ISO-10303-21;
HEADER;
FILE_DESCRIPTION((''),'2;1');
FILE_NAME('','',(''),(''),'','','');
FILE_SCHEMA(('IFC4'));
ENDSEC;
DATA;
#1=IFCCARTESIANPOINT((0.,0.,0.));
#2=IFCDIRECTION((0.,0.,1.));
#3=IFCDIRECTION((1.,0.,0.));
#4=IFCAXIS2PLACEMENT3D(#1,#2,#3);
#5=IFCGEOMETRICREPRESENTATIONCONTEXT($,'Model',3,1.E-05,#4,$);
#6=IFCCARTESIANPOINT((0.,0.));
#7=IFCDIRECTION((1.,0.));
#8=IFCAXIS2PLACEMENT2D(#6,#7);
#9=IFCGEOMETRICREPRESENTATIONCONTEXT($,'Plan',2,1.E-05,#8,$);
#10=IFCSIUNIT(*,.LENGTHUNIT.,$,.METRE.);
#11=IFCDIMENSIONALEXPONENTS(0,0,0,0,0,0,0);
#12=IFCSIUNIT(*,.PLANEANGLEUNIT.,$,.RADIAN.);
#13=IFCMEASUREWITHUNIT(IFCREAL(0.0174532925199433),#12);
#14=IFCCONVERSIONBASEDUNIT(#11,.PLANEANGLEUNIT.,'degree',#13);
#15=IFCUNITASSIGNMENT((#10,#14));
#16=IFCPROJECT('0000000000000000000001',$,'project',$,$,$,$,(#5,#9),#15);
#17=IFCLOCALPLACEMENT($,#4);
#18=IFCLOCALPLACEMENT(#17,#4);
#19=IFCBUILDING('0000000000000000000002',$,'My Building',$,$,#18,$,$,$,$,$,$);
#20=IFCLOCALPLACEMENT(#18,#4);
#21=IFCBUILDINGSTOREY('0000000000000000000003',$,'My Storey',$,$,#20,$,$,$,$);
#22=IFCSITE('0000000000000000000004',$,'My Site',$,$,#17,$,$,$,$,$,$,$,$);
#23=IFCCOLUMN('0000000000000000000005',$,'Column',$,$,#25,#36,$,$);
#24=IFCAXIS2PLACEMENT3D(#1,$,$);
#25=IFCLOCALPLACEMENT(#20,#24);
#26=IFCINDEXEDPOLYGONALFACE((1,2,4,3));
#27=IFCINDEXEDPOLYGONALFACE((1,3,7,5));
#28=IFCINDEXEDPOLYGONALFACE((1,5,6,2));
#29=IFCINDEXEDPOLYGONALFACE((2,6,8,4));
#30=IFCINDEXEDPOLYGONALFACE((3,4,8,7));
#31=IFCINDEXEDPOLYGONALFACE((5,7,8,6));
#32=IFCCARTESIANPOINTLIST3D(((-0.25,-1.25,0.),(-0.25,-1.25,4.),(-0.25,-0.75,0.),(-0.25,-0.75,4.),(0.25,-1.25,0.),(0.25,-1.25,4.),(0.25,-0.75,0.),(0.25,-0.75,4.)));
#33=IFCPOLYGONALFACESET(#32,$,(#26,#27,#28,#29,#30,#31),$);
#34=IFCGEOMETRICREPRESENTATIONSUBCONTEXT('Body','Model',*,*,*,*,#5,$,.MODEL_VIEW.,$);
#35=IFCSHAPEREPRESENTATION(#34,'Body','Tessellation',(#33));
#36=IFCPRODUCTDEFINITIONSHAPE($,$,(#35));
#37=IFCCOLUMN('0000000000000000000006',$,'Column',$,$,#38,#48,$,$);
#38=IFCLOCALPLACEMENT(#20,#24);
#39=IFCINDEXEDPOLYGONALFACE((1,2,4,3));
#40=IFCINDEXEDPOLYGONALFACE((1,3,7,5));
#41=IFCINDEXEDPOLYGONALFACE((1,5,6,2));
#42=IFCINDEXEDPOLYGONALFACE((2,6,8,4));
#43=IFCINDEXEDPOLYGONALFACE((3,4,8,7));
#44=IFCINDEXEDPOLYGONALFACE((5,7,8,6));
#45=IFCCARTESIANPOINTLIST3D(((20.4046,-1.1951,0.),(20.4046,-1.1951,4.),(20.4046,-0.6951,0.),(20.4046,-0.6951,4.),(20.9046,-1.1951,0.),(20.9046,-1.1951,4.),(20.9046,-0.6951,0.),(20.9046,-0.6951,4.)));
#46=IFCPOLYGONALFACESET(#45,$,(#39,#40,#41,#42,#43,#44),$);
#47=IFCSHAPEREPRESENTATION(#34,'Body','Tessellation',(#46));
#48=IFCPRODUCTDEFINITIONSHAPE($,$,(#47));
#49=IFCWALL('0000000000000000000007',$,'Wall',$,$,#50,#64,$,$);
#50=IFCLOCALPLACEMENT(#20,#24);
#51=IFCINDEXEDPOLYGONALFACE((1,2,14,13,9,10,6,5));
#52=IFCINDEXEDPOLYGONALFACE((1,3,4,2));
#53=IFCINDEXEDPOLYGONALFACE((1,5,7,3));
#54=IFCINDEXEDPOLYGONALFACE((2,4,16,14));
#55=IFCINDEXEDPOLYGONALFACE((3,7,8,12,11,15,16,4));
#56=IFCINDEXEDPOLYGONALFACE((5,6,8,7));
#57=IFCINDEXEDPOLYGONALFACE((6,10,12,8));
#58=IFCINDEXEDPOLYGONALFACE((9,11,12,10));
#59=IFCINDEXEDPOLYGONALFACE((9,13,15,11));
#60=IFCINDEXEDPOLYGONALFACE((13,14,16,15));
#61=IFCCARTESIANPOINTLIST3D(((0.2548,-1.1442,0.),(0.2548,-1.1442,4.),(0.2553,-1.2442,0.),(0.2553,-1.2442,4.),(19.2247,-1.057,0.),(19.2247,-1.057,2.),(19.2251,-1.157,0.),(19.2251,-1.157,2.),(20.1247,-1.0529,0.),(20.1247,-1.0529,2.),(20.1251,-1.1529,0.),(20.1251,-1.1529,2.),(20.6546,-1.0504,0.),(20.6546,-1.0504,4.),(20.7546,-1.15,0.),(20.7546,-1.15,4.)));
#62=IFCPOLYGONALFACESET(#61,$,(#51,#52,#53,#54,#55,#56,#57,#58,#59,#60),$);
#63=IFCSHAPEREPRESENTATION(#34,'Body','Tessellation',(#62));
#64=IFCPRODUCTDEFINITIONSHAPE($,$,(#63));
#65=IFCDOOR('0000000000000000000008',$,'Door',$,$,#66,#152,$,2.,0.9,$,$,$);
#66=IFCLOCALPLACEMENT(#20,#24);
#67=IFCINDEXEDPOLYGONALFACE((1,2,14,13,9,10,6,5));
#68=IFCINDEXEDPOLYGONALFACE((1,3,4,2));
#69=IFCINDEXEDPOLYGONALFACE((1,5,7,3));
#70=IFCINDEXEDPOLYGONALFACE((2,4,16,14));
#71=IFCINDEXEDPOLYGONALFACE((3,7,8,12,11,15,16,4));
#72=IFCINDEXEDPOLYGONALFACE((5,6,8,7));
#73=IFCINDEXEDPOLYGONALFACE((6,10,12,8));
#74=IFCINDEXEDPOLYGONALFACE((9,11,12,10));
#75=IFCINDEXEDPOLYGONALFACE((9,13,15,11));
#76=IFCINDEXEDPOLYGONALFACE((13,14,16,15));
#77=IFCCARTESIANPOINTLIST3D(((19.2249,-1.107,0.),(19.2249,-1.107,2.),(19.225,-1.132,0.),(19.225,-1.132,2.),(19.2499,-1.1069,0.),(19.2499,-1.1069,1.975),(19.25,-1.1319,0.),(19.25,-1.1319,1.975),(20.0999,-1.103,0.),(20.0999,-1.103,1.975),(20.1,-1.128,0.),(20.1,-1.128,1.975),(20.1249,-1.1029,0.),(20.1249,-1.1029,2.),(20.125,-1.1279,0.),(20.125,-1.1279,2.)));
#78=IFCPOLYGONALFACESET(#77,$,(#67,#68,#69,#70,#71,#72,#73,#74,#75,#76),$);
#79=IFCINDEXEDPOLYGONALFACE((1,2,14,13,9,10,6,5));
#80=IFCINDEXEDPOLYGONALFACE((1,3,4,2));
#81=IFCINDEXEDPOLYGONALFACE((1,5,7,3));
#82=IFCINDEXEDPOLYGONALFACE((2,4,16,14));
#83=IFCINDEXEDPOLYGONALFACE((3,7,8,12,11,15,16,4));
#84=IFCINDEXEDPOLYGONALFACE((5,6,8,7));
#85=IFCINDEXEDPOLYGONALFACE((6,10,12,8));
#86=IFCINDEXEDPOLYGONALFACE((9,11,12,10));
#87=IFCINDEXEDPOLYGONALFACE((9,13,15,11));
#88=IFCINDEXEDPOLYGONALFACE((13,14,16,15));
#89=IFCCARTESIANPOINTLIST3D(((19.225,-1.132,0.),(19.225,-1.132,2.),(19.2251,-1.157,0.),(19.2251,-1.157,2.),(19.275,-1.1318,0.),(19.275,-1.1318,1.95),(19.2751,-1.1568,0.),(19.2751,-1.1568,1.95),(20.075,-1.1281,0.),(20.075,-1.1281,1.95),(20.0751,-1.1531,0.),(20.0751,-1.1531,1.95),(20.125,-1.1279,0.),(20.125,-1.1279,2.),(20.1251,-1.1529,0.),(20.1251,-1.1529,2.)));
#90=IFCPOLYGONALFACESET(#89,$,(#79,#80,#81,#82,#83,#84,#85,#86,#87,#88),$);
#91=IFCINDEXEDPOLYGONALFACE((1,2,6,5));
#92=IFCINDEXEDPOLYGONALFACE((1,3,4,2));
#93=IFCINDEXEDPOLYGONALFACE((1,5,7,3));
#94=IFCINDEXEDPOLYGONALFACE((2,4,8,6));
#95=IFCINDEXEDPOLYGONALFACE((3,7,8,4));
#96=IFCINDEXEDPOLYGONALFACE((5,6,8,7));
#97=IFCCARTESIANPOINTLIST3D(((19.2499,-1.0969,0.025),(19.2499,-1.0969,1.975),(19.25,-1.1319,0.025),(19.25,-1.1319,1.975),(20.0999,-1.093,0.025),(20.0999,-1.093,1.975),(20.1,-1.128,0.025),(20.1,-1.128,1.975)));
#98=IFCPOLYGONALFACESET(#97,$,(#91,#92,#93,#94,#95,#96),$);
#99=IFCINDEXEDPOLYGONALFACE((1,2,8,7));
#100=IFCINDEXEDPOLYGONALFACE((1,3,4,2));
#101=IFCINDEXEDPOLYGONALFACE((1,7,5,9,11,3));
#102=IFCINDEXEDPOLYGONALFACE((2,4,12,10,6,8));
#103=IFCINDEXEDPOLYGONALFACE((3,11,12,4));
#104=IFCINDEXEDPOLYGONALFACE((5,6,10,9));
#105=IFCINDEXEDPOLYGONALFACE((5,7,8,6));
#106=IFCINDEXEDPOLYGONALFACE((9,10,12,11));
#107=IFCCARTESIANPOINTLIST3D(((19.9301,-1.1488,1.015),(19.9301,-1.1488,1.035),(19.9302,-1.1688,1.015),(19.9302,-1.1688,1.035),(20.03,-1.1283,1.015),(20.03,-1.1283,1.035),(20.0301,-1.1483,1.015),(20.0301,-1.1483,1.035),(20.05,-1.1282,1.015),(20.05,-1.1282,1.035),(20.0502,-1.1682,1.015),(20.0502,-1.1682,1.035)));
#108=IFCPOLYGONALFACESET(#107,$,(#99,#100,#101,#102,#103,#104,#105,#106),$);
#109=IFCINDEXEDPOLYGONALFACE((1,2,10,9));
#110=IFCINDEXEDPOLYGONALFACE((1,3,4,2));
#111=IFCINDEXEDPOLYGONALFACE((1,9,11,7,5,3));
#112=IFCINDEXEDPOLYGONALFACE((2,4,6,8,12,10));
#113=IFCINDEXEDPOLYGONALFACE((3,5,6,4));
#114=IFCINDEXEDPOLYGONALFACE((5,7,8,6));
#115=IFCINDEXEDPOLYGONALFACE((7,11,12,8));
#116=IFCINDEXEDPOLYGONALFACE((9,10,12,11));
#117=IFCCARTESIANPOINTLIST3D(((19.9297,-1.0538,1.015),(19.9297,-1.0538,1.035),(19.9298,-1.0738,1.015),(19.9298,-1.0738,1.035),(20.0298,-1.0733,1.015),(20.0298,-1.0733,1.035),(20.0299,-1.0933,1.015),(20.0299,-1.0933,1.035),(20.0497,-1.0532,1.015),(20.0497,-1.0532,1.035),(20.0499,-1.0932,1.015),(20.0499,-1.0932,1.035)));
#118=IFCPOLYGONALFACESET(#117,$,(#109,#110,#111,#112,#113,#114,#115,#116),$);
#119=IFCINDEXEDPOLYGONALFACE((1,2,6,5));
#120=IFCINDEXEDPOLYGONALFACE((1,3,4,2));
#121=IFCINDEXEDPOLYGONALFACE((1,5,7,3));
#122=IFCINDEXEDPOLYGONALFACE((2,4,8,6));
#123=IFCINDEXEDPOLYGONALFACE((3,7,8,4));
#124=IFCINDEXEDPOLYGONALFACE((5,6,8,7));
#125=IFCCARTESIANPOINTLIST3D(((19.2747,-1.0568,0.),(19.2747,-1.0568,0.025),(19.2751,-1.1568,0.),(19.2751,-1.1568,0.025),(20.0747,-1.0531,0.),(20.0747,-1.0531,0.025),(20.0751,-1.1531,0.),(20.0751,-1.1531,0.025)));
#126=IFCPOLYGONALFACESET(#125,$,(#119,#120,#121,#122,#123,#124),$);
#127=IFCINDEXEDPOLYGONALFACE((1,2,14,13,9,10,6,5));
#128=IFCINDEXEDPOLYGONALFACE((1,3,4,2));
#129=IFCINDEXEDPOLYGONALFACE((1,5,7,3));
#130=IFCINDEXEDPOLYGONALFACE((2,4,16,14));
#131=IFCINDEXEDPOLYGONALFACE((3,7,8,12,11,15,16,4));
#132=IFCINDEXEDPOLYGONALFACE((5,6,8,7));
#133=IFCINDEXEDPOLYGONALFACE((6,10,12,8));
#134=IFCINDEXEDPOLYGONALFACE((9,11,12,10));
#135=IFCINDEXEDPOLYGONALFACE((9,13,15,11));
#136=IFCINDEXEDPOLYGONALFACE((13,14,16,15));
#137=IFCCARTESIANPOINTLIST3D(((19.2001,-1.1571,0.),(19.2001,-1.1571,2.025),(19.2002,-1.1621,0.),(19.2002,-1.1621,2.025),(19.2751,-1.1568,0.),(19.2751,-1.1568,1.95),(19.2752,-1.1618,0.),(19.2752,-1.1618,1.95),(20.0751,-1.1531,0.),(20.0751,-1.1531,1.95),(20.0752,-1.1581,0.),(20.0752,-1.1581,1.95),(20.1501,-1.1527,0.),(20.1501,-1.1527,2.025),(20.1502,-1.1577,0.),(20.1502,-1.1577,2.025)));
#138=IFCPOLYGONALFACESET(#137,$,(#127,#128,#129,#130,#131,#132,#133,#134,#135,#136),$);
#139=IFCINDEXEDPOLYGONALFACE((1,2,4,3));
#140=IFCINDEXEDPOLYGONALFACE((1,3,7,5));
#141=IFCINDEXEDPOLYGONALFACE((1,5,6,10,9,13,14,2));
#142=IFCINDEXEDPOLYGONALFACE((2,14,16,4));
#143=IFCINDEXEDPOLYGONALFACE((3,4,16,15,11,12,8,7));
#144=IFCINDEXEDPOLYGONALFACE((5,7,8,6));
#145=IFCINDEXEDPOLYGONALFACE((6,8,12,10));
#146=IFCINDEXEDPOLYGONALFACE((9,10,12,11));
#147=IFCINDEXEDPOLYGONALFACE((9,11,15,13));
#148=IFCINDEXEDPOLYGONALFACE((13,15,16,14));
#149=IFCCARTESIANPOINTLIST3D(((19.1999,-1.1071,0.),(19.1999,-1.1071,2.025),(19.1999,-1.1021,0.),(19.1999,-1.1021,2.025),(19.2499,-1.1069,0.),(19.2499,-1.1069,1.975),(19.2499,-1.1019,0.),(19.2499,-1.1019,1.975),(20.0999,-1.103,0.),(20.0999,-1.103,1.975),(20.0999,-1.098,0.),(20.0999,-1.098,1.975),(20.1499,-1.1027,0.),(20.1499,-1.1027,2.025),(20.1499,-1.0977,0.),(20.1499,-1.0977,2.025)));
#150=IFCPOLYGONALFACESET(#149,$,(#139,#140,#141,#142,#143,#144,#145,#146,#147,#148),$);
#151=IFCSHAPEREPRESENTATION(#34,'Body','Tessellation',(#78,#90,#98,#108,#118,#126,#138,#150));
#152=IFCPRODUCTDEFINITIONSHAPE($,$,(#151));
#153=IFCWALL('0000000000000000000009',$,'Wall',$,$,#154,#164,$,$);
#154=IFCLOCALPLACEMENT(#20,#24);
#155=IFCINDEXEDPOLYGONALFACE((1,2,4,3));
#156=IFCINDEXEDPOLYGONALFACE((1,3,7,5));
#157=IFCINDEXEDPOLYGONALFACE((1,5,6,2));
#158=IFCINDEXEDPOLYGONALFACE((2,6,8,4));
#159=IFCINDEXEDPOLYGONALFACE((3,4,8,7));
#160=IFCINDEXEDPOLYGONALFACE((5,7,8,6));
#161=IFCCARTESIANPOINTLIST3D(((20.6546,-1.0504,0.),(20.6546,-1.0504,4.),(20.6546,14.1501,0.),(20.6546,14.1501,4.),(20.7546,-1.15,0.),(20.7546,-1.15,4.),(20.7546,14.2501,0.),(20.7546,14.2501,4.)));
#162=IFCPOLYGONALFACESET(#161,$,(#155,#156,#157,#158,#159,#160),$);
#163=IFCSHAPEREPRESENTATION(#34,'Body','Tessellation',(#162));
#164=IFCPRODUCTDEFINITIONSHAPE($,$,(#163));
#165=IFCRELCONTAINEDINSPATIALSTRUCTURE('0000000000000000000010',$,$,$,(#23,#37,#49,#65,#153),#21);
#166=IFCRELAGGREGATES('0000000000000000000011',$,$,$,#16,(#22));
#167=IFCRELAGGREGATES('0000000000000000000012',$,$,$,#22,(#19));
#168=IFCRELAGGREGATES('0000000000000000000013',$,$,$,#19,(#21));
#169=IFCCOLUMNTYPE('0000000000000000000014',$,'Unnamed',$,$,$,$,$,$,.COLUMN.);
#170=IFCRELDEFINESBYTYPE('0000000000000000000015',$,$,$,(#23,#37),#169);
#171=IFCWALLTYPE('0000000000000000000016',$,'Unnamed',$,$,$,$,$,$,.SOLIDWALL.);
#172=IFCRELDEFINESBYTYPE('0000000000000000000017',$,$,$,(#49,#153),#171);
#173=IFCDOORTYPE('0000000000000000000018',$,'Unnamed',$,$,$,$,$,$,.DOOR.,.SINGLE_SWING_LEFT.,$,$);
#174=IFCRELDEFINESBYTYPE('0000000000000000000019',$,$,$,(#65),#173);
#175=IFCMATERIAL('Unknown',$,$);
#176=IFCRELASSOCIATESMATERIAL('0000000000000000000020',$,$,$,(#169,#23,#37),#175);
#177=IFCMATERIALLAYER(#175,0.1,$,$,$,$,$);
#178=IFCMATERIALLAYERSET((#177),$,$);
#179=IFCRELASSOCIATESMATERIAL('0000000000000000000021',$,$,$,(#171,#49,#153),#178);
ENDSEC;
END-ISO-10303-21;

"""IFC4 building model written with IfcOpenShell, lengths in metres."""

from ifc_helpers import new_model, entity, si_unit, converted_unit, frame, origin_with_axes, origin_2d_with_axis, place, context, subcontext, project, spatial, line, indexed_curve, rectangle, outline, extrude, shape, source, transform, mapped, material, layer, layer_set, layer_usage, material_profile, profile_set, profile_usage, type_object, type_shapes, element, fill, save


model = new_model("IFC4")

# Units and contexts
model_context = context("Model", 3, precision=1e-05, world=origin_with_axes())
plan_context = context("Plan", 2, precision=1e-05, world=origin_2d_with_axis())
body_context_1 = subcontext(model_context, "Body", "Model", "MODEL_VIEW")
body_context_2 = subcontext(plan_context, "Body", "Plan", "PLAN_VIEW")
ifc_project = project(units=[si_unit("LENGTHUNIT", "METRE"), converted_unit("PLANEANGLEUNIT", "degree", entity("IfcReal", 0.0174532925199433), si_unit("PLANEANGLEUNIT", "RADIAN"), dimensions=[0, 0, 0, 0, 0, 0, 0])], contexts=[model_context, plan_context])

# Site, building, storey
site_placement = place(None, origin_with_axes())
site = spatial("IfcSite", under=ifc_project, at=site_placement, Name="My Site")
building_placement = place(site_placement, origin_with_axes())
building = spatial("IfcBuilding", under=site, at=building_placement, Name="My Building")
storey_placement = place(building_placement, origin_with_axes())
storey = spatial("IfcBuildingStorey", under=building, at=storey_placement, Name="My Storey")

# Columns
ifc_material = material(Name="Unknown")
ifc_material_profile_1 = material_profile(ifc_material, rectangle(XDim=0.5, YDim=0.5))
ifc_profile_set_1 = profile_set([ifc_material_profile_1])
ifc_profile_usage_1 = profile_usage(ifc_profile_set_1, cardinal=5)
column_type = type_object("IfcColumnType", Name="Unnamed", PredefinedType="COLUMN", material=ifc_profile_set_1)
column_1_placement = place(storey_placement, frame((0.0, -1.0, 0.0), z_axis=(0.0, 0.0, 1.0), x_axis=(1.0, 0.0, 0.0)))
element("IfcColumn", 1, at=column_1_placement, inside=storey, type_object=column_type, material=ifc_profile_usage_1, Name="Column", context=body_context_1, shape_type="SweptSolid", body=[
    extrude(rectangle(XDim=0.5, YDim=0.5), origin_with_axes(), (0.0, 0.0, 1.0), 4.0),
])
ifc_profile_usage_2 = profile_usage(ifc_profile_set_1, cardinal=5)
column_2_placement = place(storey_placement, frame((20.6546, -0.9451, 0.0), z_axis=(0.0, 0.0, 1.0), x_axis=(1.0, 0.0, 0.0)))
element("IfcColumn", 2, at=column_2_placement, inside=storey, type_object=column_type, material=ifc_profile_usage_2, Name="Column", context=body_context_1, shape_type="SweptSolid", body=[
    extrude(rectangle(XDim=0.5, YDim=0.5), origin_with_axes(), (0.0, 0.0, 1.0), 4.0),
])

# Wall, opening, door
ifc_layer = layer(ifc_material, 0.1)
ifc_layer_set = layer_set([ifc_layer])
ifc_layer_usage_1 = layer_usage(ifc_layer_set, "AXIS2", "POSITIVE", 0.0)
wall_type = type_object("IfcWallType", Name="Unnamed", PredefinedType="SOLIDWALL", material=ifc_layer_set)
wall_1_placement = place(storey_placement, frame((0.2553, -1.2442, 0.0), z_axis=(0.0, 0.0, 1.0), x_axis=(0.999989, 0.004596, 0.0)))
wall_1 = element("IfcWall", 3, at=wall_1_placement, inside=storey, type_object=wall_type, material=ifc_layer_usage_1, Name="Wall", context=body_context_1, shape_type="SweptSolid", body=[
    extrude(outline(indexed_curve([(0.0, 0.0), (0.0, 0.1), (20.4, 0.1), (20.4995, 0.0)], segments=[line(1, 2, 3, 4, 1)])), origin_with_axes(), (0.0, 0.0, 1.0), 4.0),
])
shared_shape_1 = source(origin_with_axes(), body_context_1, "Body", "SweptSolid", [
    extrude(outline(indexed_curve([(0.0, 0.0), (0.9, 0.0), (0.9, 2.0), (0.0, 2.0)], segments=[line(1, 2, 3, 4, 1)])), frame((0.0, -0.6, 0.0), z_axis=(0.0, -1.0, 0.0), x_axis=(1.0, 0.0, 0.0)), (0.0, 0.0, -1.0), 1.2),
])
opening_1_placement = place(wall_1_placement, frame((18.97, 0.0, 0.0), z_axis=(0.0, 0.0, 1.0), x_axis=(1.0, 0.0, 0.0)))
opening_1 = element("IfcOpeningElement", 4, at=opening_1_placement, cuts=wall_1, PredefinedType="OPENING", context=body_context_1, shape_type="MappedRepresentation", body=[
    mapped(shared_shape_1, transform((0.0, 0.0, 0.0), x_axis=(1.0, 0.0, 0.0), y_axis=(0.0, 1.0, 0.0), z_axis=(0.0, 0.0, 1.0), scale=1.0)),
])
door_type = type_object("IfcDoorType", Name="Unnamed", OperationType="SINGLE_SWING_LEFT", PredefinedType="DOOR")
shared_shape_2 = source(origin_with_axes(), body_context_1, "Body", "SweptSolid", [
    extrude(outline(indexed_curve([(0.0, 0.0), (0.0, 2.0), (0.9, 2.0), (0.9, 0.0), (0.875, 0.0), (0.875, 1.975), (0.025, 1.975), (0.025, 0.0)], segments=[line(1, 2, 3, 4, 5, 6, 7, 8, 1)])), frame((0.0, 0.025, 0.0), z_axis=(0.0, -1.0, 0.0), x_axis=(1.0, 0.0, 0.0)), (0.0, 0.0, -1.0), 0.025),
    extrude(outline(indexed_curve([(0.0, 0.0), (0.0, 2.0), (0.9, 2.0), (0.9, 0.0), (0.85, 0.0), (0.85, 1.95), (0.05, 1.95), (0.05, 0.0)], segments=[line(1, 2, 3, 4, 5, 6, 7, 8, 1)])), frame((0.0, 0.0, 0.0), z_axis=(0.0, -1.0, 0.0), x_axis=(1.0, 0.0, 0.0)), (0.0, 0.0, -1.0), 0.025),
    extrude(outline(indexed_curve([(0.0, 0.0), (0.85, 0.0), (0.85, 0.035), (0.0, 0.035)], segments=[line(1, 2, 3, 4, 1)])), frame((0.025, 0.025, 0.025), z_axis=(0.0, 0.0, 1.0), x_axis=(1.0, 0.0, 0.0)), (0.0, 0.0, 1.0), 1.95),
    extrude(outline(indexed_curve([(0.0, 0.0), (0.0, -0.04), (-0.12, -0.04), (-0.12, -0.02), (-0.02, -0.02), (-0.02, 0.0)], segments=[line(1, 2, 3, 4, 5, 6, 1)])), frame((0.825, 0.025, 1.015), z_axis=(0.0, 0.0, 1.0), x_axis=(1.0, 0.0, 0.0)), (0.0, 0.0, 1.0), 0.02),
    extrude(outline(indexed_curve([(0.0, 0.0), (0.0, 0.04), (-0.12, 0.04), (-0.12, 0.02), (-0.02, 0.02), (-0.02, 0.0)], segments=[line(1, 2, 3, 4, 5, 6, 1)])), frame((0.825, 0.06, 1.015), z_axis=(0.0, 0.0, 1.0), x_axis=(1.0, 0.0, 0.0)), (0.0, 0.0, 1.0), 0.02),
    extrude(outline(indexed_curve([(0.0, 0.0), (0.8, 0.0), (0.8, 0.1), (0.0, 0.1)], segments=[line(1, 2, 3, 4, 1)])), frame((0.05, 0.0, 0.0), z_axis=(0.0, 0.0, 1.0), x_axis=(1.0, 0.0, 0.0)), (0.0, 0.0, 1.0), 0.025),
    extrude(outline(indexed_curve([(0.0, 0.0), (0.0, 2.025), (0.95, 2.025), (0.95, 0.0), (0.875, 0.0), (0.875, 1.95), (0.075, 1.95), (0.075, 0.0)], segments=[line(1, 2, 3, 4, 5, 6, 7, 8, 1)])), frame((-0.025, -0.005, 0.0), z_axis=(0.0, -1.0, 0.0), x_axis=(1.0, 0.0, 0.0)), (0.0, 0.0, -1.0), 0.005),
    extrude(outline(indexed_curve([(0.0, 0.0), (0.0, 2.025), (0.95, 2.025), (0.95, 0.0), (0.9, 0.0), (0.9, 1.975), (0.05, 1.975), (0.05, 0.0)], segments=[line(1, 2, 3, 4, 5, 6, 7, 8, 1)])), frame((-0.025, 0.05, 0.0), z_axis=(0.0, -1.0, 0.0), x_axis=(1.0, 0.0, 0.0)), (0.0, 0.0, -1.0), 0.005),
])
shared_shape_3 = source(origin_with_axes(), body_context_2, "Body", "Curve2D", [
    entity("IfcIndexedPolyCurve", entity("IfcCartesianPointList2D", [[0.0, 0.0], [0.0, 0.05], [0.025, 0.05], [0.025, 0.025], [0.05, 0.025], [0.05, 0.0]]), [entity("IfcLineIndex", [1, 2, 3, 4, 5, 6, 1])]),
    entity("IfcIndexedPolyCurve", entity("IfcCartesianPointList2D", [[0.9, 0.0], [0.9, 0.05], [0.875, 0.05], [0.875, 0.025], [0.85, 0.025], [0.85, 0.0]]), [entity("IfcLineIndex", [1, 2, 3, 4, 5, 6, 1])]),
    entity("IfcTrimmedCurve", entity("IfcEllipse", entity("IfcAxis2Placement2D", entity("IfcCartesianPoint", [0.06, 0.05]), entity("IfcDirection", [1.0, 0.0])), 0.815, 0.85), [entity("IfcCartesianPoint", [0.875, 0.05])], [entity("IfcCartesianPoint", [0.06, 0.9])], True, "CARTESIAN"),
    entity("IfcIndexedPolyCurve", entity("IfcCartesianPointList2D", [[0.025, 0.05], [0.06, 0.05], [0.06, 0.9], [0.025, 0.9]]), [entity("IfcLineIndex", [1, 2, 3, 4, 1])]),
])
type_shapes(door_type, [shared_shape_2, shared_shape_3])
door_1_placement = place(opening_1_placement, frame((0.0, 0.0, 0.0), z_axis=(0.0, 0.0, 1.0), x_axis=(1.0, 0.0, 0.0)))
door_1 = element("IfcDoor", 5, at=door_1_placement, inside=storey, type_object=door_type, Name="Door", OverallHeight=2.0, OverallWidth=0.9, shapes=[
    shape(body_context_1, "Body", "MappedRepresentation", [mapped(shared_shape_2, transform((0.0, 0.0, 0.0), x_axis=(1.0, 0.0, 0.0), y_axis=(0.0, 1.0, 0.0), z_axis=(0.0, 0.0, 1.0), scale=1.0))]),
    shape(body_context_2, "Body", "MappedRepresentation", [mapped(shared_shape_3, transform((0.0, 0.0, 0.0), x_axis=(1.0, 0.0, 0.0), y_axis=(0.0, 1.0, 0.0), z_axis=(0.0, 0.0, 1.0), scale=1.0))]),
])
fill(opening_1, door_1)

# Wall
ifc_layer_usage_2 = layer_usage(ifc_layer_set, "AXIS2", "POSITIVE", 0.0)
wall_2_placement = place(storey_placement, frame((20.7546, -1.15, 0.0), z_axis=(0.0, 0.0, 1.0), x_axis=(0.0, 1.0, 0.0)))
element("IfcWall", 6, at=wall_2_placement, inside=storey, type_object=wall_type, material=ifc_layer_usage_2, Name="Wall", context=body_context_1, shape_type="SweptSolid", body=[
    extrude(outline(indexed_curve([(0.0, 0.0), (0.0995, 0.1), (15.3, 0.1), (15.4, 0.0)], segments=[line(1, 2, 3, 4, 1)])), origin_with_axes(), (0.0, 0.0, 1.0), 4.0),
])

save(model, "model.ifc")
